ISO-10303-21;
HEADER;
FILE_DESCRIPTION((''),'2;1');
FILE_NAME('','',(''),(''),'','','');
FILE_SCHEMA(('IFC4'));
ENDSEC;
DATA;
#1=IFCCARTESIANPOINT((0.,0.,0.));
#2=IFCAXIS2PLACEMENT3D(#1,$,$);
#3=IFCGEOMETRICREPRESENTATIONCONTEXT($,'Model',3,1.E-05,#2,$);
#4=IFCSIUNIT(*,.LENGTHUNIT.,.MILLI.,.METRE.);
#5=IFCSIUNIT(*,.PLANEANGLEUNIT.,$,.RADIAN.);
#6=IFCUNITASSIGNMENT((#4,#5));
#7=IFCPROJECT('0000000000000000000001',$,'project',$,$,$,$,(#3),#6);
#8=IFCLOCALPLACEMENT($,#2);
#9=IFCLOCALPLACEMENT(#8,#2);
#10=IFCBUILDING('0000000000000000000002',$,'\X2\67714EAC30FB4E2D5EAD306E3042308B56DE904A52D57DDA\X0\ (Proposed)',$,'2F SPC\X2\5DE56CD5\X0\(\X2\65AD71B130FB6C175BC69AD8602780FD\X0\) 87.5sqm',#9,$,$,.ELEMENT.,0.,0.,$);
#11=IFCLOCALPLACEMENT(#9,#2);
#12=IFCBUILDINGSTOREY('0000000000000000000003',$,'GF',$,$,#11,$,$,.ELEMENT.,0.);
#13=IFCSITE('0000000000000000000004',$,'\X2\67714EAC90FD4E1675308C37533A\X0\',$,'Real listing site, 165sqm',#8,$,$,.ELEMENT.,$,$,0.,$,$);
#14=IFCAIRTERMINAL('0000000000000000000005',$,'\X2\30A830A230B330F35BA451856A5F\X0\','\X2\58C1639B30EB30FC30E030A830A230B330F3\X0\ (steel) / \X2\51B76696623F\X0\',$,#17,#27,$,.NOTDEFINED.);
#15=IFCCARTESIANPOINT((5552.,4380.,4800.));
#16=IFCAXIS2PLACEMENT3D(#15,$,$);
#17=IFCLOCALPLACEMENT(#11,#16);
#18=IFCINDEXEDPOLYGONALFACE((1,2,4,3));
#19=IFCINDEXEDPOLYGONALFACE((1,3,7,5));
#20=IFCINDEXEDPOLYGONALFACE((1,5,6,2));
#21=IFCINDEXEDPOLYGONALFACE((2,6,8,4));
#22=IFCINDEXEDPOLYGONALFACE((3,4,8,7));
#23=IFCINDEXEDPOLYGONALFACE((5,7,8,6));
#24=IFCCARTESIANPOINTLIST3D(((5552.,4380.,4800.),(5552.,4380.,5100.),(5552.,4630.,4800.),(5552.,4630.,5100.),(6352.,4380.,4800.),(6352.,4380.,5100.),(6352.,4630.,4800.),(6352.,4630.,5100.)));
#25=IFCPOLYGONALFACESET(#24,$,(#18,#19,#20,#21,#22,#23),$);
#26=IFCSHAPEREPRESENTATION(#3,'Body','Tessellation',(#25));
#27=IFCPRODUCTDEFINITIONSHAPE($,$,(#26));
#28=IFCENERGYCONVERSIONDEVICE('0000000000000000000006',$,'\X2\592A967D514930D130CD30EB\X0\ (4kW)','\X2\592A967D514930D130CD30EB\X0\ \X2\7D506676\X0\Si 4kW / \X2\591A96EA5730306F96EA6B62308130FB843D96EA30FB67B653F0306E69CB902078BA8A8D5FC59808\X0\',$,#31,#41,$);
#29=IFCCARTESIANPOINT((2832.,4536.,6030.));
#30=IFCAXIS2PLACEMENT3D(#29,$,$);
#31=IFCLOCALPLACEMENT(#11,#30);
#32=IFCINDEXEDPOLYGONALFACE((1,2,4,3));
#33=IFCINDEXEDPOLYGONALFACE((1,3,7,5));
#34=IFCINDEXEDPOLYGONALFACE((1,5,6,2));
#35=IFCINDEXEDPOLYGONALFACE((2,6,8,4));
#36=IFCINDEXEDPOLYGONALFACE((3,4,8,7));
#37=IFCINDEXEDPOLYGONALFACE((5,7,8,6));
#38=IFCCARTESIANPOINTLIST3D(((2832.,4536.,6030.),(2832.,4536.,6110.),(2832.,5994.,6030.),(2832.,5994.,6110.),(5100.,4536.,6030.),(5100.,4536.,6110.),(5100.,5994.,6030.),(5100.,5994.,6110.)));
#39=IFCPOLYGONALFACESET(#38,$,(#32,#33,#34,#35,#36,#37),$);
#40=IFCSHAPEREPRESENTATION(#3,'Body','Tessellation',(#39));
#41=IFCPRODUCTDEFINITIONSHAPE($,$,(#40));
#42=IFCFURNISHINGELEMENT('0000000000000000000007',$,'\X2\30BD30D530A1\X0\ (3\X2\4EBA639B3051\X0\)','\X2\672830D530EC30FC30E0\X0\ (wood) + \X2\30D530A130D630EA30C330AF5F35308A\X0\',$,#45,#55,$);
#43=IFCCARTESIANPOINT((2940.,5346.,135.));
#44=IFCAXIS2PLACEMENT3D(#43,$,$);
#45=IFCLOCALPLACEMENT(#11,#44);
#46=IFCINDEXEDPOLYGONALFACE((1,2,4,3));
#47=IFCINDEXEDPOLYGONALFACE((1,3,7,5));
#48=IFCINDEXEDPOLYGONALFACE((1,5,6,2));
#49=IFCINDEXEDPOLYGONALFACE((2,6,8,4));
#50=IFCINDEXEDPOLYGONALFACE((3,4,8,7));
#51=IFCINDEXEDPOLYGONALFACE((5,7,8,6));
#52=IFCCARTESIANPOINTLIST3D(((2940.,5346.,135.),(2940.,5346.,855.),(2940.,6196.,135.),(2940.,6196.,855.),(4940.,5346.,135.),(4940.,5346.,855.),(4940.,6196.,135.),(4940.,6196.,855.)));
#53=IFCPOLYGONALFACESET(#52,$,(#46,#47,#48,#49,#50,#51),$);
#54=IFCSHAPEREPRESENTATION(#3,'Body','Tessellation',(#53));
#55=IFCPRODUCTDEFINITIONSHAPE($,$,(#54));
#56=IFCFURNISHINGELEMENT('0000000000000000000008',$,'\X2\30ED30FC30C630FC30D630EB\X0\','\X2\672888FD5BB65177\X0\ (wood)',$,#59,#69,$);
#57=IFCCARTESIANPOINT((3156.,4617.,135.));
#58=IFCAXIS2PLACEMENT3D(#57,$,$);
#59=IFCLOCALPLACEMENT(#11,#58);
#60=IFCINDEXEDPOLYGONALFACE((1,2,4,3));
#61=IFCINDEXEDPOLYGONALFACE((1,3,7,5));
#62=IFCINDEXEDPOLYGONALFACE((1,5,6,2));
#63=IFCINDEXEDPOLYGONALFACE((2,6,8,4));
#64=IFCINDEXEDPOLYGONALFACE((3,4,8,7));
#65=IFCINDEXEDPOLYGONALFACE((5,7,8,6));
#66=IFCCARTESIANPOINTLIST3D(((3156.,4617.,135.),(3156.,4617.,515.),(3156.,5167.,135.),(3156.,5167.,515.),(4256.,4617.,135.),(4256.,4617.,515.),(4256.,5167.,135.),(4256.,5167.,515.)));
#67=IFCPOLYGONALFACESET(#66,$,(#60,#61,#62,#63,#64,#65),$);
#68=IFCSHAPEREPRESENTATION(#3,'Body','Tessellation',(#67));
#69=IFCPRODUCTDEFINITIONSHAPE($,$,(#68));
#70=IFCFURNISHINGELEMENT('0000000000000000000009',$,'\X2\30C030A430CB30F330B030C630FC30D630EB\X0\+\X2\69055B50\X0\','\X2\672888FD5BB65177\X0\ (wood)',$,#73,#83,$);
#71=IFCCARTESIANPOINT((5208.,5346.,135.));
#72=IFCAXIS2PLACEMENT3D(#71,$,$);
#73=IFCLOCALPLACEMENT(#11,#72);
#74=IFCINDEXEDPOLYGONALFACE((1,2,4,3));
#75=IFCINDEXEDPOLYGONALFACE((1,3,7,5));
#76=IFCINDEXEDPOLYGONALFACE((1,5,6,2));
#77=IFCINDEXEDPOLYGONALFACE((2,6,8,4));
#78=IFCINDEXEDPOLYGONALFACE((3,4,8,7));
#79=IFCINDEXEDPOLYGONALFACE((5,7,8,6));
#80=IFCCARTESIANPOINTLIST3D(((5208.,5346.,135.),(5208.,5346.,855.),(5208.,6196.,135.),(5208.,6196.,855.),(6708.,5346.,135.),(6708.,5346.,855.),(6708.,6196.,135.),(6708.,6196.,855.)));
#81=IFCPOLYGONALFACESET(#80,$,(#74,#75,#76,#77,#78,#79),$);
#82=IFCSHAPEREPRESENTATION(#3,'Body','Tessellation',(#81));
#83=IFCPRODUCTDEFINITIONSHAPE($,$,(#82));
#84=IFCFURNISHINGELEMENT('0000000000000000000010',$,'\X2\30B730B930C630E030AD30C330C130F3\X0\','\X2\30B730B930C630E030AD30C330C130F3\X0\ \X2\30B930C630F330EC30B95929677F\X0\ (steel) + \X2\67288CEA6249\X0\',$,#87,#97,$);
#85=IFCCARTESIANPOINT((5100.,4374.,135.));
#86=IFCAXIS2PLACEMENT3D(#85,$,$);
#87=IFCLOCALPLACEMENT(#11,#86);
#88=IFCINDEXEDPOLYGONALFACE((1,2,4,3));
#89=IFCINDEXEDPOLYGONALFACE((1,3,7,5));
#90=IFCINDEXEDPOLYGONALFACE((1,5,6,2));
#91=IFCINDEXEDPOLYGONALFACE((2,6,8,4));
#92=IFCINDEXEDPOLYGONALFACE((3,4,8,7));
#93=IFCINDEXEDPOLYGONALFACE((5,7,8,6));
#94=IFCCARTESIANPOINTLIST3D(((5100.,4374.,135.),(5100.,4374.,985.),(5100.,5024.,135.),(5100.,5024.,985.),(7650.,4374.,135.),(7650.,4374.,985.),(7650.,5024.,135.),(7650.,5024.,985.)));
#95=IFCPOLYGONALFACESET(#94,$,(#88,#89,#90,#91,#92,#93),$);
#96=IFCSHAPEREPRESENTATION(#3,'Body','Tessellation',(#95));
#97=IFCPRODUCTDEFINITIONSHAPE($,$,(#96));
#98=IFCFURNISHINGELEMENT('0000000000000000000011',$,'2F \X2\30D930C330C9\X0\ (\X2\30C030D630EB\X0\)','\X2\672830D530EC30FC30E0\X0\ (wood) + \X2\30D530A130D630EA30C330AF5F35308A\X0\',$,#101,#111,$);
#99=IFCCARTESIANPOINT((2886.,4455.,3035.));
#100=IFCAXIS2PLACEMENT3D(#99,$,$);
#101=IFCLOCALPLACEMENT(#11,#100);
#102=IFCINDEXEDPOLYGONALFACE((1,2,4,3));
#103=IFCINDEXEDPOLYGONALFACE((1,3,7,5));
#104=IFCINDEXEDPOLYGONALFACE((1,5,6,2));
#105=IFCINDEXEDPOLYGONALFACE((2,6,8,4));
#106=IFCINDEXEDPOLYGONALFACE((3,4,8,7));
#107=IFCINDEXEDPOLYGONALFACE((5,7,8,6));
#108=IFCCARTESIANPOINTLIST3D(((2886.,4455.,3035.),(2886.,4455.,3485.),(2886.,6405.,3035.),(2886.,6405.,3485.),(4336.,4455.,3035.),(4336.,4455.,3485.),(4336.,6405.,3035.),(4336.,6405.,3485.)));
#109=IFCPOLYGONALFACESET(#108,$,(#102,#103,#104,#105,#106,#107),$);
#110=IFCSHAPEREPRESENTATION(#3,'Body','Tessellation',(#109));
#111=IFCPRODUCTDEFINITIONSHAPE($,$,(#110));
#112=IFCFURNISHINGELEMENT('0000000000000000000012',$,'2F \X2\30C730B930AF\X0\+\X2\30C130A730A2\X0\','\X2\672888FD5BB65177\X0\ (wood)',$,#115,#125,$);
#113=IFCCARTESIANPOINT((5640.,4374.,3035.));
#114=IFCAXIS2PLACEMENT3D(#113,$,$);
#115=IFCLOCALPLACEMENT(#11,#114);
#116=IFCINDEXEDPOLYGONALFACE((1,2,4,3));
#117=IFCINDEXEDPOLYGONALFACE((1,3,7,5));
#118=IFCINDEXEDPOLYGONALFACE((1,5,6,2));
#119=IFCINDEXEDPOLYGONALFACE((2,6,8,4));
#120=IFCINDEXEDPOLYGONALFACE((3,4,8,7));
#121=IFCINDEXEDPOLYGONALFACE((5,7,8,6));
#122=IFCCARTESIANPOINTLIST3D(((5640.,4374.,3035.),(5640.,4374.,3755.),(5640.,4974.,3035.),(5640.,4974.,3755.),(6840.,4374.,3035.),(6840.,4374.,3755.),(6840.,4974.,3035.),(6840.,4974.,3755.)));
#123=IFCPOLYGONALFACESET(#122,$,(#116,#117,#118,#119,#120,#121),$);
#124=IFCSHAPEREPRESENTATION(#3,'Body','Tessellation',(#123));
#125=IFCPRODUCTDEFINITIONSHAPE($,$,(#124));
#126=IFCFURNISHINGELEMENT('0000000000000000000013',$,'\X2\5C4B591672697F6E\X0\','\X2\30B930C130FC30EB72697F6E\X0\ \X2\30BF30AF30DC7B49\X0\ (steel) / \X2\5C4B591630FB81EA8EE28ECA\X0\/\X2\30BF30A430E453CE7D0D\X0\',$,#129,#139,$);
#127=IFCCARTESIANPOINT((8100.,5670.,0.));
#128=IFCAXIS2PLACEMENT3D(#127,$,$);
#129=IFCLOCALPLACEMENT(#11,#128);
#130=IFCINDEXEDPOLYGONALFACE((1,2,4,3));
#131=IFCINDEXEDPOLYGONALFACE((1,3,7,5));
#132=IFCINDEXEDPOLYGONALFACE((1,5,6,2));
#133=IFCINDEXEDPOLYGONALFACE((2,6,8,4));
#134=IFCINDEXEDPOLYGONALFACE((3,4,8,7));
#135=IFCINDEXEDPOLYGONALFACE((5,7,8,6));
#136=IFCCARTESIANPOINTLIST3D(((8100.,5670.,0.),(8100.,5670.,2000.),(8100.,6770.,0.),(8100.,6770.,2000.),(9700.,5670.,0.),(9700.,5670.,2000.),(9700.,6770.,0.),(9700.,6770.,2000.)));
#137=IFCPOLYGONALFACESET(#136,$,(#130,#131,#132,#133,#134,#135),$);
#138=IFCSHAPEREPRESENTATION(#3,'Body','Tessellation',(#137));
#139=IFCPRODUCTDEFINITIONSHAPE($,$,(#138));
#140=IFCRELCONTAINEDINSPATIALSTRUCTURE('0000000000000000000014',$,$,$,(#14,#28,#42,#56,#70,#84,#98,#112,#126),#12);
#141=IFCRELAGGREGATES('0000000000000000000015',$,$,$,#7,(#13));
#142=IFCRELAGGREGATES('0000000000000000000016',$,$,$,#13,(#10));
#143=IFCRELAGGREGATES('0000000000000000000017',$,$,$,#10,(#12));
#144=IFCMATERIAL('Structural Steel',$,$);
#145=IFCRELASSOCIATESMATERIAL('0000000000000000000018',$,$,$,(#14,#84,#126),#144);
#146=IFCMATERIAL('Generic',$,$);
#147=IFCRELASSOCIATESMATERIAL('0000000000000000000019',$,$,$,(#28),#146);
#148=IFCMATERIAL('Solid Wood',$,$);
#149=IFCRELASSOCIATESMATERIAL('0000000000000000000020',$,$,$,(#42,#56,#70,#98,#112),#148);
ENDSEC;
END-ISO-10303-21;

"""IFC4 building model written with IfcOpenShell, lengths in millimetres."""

from ifc_helpers import new_model, si_unit, frame, frame_2d, origin, place, context, project, spatial, rectangle, extrude, material, element, save


model = new_model("IFC4")

# Units and contexts
model_context = context("Model", 3, precision=1e-05, world=origin())
ifc_project = project(units=[si_unit("LENGTHUNIT", "METRE", prefix="MILLI"), si_unit("PLANEANGLEUNIT", "RADIAN")], contexts=[model_context])

# Site, building, storey
site_placement = place(None, origin())
site = spatial("IfcSite", under=ifc_project, at=site_placement, Name="東京都世田谷区", ObjectType="Real listing site, 165sqm", CompositionType="ELEMENT", RefElevation=0.0)
building_placement = place(site_placement, origin())
building = spatial("IfcBuilding", under=site, at=building_placement, Name="東京・中庭のある回遊動線 (Proposed)", ObjectType="2F SPC工法(断熱・気密高性能) 87.5sqm", CompositionType="ELEMENT", ElevationOfRefHeight=0.0, ElevationOfTerrain=0.0)
storey_placement = place(building_placement, origin())
storey = spatial("IfcBuildingStorey", under=building, at=storey_placement, Name="GF", CompositionType="ELEMENT", Elevation=0.0)

# Shared definitions
ifc_material_1 = material(Name="Solid Wood")

# Shared definitions
ifc_material_2 = material(Name="Generic")

# Shared definitions
ifc_material_3 = material(Name="Structural Steel")

# Air terminal
air_terminal_1_placement = place(storey_placement, frame((5552.0, 4380.0, 4800.0)))
element("IfcAirTerminal", 1, at=air_terminal_1_placement, inside=storey, material=ifc_material_3, Name="エアコン室内機", Description="壁掛ルームエアコン (steel) / 冷暖房", PredefinedType="NOTDEFINED", context=model_context, shape_type="SweptSolid", body=[
    extrude(rectangle(XDim=800.0, YDim=250.0, at=frame_2d((400.0, 125.0))), frame((5552.0, 4380.0, 4800.0)), (0.0, 0.0, 1.0), 300.0),
])

# Energy conversion device
energy_conversion_device_placement = place(storey_placement, frame((2832.0, 4536.0, 6030.0)))
element("IfcEnergyConversionDevice", 2, at=energy_conversion_device_placement, inside=storey, material=ifc_material_2, Name="太陽光パネル (4kW)", Description="太陽光パネル 結晶Si 4kW / 多雪地は雪止め・落雪・架台の構造確認必須", context=model_context, shape_type="SweptSolid", body=[
    extrude(rectangle(XDim=2268.0, YDim=1458.0, at=frame_2d((1134.0, 729.0))), frame((2832.0, 4536.0, 6030.0)), (0.0, 0.0, 1.0), 80.0),
])

# Furnishing elements
furnishing_1_placement = place(storey_placement, frame((2940.0, 5346.0, 135.0)))
element("IfcFurnishingElement", 3, at=furnishing_1_placement, inside=storey, material=ifc_material_1, Name="ソファ (3人掛け)", Description="木フレーム (wood) + ファブリック張り", context=model_context, shape_type="SweptSolid", body=[
    extrude(rectangle(XDim=2000.0, YDim=850.0, at=frame_2d((1000.0, 425.0))), frame((2940.0, 5346.0, 135.0)), (0.0, 0.0, 1.0), 720.0),
])
furnishing_2_placement = place(storey_placement, frame((3156.0, 4617.0, 135.0)))
element("IfcFurnishingElement", 4, at=furnishing_2_placement, inside=storey, material=ifc_material_1, Name="ローテーブル", Description="木製家具 (wood)", context=model_context, shape_type="SweptSolid", body=[
    extrude(rectangle(XDim=1100.0, YDim=550.0, at=frame_2d((550.0, 275.0))), frame((3156.0, 4617.0, 135.0)), (0.0, 0.0, 1.0), 380.0),
])
furnishing_3_placement = place(storey_placement, frame((5208.0, 5346.0, 135.0)))
element("IfcFurnishingElement", 5, at=furnishing_3_placement, inside=storey, material=ifc_material_1, Name="ダイニングテーブル+椅子", Description="木製家具 (wood)", context=model_context, shape_type="SweptSolid", body=[
    extrude(rectangle(XDim=1500.0, YDim=850.0, at=frame_2d((750.0, 425.0))), frame((5208.0, 5346.0, 135.0)), (0.0, 0.0, 1.0), 720.0),
])
furnishing_4_placement = place(storey_placement, frame((5100.0, 4374.0, 135.0)))
element("IfcFurnishingElement", 6, at=furnishing_4_placement, inside=storey, material=ifc_material_3, Name="システムキッチン", Description="システムキッチン ステンレス天板 (steel) + 木質扉", context=model_context, shape_type="SweptSolid", body=[
    extrude(rectangle(XDim=2550.0, YDim=650.0, at=frame_2d((1275.0, 325.0))), frame((5100.0, 4374.0, 135.0)), (0.0, 0.0, 1.0), 850.0),
])
furnishing_5_placement = place(storey_placement, frame((2886.0, 4455.0, 3035.0)))
element("IfcFurnishingElement", 7, at=furnishing_5_placement, inside=storey, material=ifc_material_1, Name="2F ベッド (ダブル)", Description="木フレーム (wood) + ファブリック張り", context=model_context, shape_type="SweptSolid", body=[
    extrude(rectangle(XDim=1450.0, YDim=1950.0, at=frame_2d((725.0, 975.0))), frame((2886.0, 4455.0, 3035.0)), (0.0, 0.0, 1.0), 450.0),
])
furnishing_6_placement = place(storey_placement, frame((5640.0, 4374.0, 3035.0)))
element("IfcFurnishingElement", 8, at=furnishing_6_placement, inside=storey, material=ifc_material_1, Name="2F デスク+チェア", Description="木製家具 (wood)", context=model_context, shape_type="SweptSolid", body=[
    extrude(rectangle(XDim=1200.0, YDim=600.0, at=frame_2d((600.0, 300.0))), frame((5640.0, 4374.0, 3035.0)), (0.0, 0.0, 1.0), 720.0),
])
furnishing_7_placement = place(storey_placement, frame((8100.0, 5670.0, 0.0)))
element("IfcFurnishingElement", 9, at=furnishing_7_placement, inside=storey, material=ifc_material_3, Name="屋外物置", Description="スチール物置 タクボ等 (steel) / 屋外・自転車/タイヤ収納", context=model_context, shape_type="SweptSolid", body=[
    extrude(rectangle(XDim=1600.0, YDim=1100.0, at=frame_2d((800.0, 550.0))), frame((8100.0, 5670.0, 0.0)), (0.0, 0.0, 1.0), 2000.0),
])

save(model, "model.ifc")
